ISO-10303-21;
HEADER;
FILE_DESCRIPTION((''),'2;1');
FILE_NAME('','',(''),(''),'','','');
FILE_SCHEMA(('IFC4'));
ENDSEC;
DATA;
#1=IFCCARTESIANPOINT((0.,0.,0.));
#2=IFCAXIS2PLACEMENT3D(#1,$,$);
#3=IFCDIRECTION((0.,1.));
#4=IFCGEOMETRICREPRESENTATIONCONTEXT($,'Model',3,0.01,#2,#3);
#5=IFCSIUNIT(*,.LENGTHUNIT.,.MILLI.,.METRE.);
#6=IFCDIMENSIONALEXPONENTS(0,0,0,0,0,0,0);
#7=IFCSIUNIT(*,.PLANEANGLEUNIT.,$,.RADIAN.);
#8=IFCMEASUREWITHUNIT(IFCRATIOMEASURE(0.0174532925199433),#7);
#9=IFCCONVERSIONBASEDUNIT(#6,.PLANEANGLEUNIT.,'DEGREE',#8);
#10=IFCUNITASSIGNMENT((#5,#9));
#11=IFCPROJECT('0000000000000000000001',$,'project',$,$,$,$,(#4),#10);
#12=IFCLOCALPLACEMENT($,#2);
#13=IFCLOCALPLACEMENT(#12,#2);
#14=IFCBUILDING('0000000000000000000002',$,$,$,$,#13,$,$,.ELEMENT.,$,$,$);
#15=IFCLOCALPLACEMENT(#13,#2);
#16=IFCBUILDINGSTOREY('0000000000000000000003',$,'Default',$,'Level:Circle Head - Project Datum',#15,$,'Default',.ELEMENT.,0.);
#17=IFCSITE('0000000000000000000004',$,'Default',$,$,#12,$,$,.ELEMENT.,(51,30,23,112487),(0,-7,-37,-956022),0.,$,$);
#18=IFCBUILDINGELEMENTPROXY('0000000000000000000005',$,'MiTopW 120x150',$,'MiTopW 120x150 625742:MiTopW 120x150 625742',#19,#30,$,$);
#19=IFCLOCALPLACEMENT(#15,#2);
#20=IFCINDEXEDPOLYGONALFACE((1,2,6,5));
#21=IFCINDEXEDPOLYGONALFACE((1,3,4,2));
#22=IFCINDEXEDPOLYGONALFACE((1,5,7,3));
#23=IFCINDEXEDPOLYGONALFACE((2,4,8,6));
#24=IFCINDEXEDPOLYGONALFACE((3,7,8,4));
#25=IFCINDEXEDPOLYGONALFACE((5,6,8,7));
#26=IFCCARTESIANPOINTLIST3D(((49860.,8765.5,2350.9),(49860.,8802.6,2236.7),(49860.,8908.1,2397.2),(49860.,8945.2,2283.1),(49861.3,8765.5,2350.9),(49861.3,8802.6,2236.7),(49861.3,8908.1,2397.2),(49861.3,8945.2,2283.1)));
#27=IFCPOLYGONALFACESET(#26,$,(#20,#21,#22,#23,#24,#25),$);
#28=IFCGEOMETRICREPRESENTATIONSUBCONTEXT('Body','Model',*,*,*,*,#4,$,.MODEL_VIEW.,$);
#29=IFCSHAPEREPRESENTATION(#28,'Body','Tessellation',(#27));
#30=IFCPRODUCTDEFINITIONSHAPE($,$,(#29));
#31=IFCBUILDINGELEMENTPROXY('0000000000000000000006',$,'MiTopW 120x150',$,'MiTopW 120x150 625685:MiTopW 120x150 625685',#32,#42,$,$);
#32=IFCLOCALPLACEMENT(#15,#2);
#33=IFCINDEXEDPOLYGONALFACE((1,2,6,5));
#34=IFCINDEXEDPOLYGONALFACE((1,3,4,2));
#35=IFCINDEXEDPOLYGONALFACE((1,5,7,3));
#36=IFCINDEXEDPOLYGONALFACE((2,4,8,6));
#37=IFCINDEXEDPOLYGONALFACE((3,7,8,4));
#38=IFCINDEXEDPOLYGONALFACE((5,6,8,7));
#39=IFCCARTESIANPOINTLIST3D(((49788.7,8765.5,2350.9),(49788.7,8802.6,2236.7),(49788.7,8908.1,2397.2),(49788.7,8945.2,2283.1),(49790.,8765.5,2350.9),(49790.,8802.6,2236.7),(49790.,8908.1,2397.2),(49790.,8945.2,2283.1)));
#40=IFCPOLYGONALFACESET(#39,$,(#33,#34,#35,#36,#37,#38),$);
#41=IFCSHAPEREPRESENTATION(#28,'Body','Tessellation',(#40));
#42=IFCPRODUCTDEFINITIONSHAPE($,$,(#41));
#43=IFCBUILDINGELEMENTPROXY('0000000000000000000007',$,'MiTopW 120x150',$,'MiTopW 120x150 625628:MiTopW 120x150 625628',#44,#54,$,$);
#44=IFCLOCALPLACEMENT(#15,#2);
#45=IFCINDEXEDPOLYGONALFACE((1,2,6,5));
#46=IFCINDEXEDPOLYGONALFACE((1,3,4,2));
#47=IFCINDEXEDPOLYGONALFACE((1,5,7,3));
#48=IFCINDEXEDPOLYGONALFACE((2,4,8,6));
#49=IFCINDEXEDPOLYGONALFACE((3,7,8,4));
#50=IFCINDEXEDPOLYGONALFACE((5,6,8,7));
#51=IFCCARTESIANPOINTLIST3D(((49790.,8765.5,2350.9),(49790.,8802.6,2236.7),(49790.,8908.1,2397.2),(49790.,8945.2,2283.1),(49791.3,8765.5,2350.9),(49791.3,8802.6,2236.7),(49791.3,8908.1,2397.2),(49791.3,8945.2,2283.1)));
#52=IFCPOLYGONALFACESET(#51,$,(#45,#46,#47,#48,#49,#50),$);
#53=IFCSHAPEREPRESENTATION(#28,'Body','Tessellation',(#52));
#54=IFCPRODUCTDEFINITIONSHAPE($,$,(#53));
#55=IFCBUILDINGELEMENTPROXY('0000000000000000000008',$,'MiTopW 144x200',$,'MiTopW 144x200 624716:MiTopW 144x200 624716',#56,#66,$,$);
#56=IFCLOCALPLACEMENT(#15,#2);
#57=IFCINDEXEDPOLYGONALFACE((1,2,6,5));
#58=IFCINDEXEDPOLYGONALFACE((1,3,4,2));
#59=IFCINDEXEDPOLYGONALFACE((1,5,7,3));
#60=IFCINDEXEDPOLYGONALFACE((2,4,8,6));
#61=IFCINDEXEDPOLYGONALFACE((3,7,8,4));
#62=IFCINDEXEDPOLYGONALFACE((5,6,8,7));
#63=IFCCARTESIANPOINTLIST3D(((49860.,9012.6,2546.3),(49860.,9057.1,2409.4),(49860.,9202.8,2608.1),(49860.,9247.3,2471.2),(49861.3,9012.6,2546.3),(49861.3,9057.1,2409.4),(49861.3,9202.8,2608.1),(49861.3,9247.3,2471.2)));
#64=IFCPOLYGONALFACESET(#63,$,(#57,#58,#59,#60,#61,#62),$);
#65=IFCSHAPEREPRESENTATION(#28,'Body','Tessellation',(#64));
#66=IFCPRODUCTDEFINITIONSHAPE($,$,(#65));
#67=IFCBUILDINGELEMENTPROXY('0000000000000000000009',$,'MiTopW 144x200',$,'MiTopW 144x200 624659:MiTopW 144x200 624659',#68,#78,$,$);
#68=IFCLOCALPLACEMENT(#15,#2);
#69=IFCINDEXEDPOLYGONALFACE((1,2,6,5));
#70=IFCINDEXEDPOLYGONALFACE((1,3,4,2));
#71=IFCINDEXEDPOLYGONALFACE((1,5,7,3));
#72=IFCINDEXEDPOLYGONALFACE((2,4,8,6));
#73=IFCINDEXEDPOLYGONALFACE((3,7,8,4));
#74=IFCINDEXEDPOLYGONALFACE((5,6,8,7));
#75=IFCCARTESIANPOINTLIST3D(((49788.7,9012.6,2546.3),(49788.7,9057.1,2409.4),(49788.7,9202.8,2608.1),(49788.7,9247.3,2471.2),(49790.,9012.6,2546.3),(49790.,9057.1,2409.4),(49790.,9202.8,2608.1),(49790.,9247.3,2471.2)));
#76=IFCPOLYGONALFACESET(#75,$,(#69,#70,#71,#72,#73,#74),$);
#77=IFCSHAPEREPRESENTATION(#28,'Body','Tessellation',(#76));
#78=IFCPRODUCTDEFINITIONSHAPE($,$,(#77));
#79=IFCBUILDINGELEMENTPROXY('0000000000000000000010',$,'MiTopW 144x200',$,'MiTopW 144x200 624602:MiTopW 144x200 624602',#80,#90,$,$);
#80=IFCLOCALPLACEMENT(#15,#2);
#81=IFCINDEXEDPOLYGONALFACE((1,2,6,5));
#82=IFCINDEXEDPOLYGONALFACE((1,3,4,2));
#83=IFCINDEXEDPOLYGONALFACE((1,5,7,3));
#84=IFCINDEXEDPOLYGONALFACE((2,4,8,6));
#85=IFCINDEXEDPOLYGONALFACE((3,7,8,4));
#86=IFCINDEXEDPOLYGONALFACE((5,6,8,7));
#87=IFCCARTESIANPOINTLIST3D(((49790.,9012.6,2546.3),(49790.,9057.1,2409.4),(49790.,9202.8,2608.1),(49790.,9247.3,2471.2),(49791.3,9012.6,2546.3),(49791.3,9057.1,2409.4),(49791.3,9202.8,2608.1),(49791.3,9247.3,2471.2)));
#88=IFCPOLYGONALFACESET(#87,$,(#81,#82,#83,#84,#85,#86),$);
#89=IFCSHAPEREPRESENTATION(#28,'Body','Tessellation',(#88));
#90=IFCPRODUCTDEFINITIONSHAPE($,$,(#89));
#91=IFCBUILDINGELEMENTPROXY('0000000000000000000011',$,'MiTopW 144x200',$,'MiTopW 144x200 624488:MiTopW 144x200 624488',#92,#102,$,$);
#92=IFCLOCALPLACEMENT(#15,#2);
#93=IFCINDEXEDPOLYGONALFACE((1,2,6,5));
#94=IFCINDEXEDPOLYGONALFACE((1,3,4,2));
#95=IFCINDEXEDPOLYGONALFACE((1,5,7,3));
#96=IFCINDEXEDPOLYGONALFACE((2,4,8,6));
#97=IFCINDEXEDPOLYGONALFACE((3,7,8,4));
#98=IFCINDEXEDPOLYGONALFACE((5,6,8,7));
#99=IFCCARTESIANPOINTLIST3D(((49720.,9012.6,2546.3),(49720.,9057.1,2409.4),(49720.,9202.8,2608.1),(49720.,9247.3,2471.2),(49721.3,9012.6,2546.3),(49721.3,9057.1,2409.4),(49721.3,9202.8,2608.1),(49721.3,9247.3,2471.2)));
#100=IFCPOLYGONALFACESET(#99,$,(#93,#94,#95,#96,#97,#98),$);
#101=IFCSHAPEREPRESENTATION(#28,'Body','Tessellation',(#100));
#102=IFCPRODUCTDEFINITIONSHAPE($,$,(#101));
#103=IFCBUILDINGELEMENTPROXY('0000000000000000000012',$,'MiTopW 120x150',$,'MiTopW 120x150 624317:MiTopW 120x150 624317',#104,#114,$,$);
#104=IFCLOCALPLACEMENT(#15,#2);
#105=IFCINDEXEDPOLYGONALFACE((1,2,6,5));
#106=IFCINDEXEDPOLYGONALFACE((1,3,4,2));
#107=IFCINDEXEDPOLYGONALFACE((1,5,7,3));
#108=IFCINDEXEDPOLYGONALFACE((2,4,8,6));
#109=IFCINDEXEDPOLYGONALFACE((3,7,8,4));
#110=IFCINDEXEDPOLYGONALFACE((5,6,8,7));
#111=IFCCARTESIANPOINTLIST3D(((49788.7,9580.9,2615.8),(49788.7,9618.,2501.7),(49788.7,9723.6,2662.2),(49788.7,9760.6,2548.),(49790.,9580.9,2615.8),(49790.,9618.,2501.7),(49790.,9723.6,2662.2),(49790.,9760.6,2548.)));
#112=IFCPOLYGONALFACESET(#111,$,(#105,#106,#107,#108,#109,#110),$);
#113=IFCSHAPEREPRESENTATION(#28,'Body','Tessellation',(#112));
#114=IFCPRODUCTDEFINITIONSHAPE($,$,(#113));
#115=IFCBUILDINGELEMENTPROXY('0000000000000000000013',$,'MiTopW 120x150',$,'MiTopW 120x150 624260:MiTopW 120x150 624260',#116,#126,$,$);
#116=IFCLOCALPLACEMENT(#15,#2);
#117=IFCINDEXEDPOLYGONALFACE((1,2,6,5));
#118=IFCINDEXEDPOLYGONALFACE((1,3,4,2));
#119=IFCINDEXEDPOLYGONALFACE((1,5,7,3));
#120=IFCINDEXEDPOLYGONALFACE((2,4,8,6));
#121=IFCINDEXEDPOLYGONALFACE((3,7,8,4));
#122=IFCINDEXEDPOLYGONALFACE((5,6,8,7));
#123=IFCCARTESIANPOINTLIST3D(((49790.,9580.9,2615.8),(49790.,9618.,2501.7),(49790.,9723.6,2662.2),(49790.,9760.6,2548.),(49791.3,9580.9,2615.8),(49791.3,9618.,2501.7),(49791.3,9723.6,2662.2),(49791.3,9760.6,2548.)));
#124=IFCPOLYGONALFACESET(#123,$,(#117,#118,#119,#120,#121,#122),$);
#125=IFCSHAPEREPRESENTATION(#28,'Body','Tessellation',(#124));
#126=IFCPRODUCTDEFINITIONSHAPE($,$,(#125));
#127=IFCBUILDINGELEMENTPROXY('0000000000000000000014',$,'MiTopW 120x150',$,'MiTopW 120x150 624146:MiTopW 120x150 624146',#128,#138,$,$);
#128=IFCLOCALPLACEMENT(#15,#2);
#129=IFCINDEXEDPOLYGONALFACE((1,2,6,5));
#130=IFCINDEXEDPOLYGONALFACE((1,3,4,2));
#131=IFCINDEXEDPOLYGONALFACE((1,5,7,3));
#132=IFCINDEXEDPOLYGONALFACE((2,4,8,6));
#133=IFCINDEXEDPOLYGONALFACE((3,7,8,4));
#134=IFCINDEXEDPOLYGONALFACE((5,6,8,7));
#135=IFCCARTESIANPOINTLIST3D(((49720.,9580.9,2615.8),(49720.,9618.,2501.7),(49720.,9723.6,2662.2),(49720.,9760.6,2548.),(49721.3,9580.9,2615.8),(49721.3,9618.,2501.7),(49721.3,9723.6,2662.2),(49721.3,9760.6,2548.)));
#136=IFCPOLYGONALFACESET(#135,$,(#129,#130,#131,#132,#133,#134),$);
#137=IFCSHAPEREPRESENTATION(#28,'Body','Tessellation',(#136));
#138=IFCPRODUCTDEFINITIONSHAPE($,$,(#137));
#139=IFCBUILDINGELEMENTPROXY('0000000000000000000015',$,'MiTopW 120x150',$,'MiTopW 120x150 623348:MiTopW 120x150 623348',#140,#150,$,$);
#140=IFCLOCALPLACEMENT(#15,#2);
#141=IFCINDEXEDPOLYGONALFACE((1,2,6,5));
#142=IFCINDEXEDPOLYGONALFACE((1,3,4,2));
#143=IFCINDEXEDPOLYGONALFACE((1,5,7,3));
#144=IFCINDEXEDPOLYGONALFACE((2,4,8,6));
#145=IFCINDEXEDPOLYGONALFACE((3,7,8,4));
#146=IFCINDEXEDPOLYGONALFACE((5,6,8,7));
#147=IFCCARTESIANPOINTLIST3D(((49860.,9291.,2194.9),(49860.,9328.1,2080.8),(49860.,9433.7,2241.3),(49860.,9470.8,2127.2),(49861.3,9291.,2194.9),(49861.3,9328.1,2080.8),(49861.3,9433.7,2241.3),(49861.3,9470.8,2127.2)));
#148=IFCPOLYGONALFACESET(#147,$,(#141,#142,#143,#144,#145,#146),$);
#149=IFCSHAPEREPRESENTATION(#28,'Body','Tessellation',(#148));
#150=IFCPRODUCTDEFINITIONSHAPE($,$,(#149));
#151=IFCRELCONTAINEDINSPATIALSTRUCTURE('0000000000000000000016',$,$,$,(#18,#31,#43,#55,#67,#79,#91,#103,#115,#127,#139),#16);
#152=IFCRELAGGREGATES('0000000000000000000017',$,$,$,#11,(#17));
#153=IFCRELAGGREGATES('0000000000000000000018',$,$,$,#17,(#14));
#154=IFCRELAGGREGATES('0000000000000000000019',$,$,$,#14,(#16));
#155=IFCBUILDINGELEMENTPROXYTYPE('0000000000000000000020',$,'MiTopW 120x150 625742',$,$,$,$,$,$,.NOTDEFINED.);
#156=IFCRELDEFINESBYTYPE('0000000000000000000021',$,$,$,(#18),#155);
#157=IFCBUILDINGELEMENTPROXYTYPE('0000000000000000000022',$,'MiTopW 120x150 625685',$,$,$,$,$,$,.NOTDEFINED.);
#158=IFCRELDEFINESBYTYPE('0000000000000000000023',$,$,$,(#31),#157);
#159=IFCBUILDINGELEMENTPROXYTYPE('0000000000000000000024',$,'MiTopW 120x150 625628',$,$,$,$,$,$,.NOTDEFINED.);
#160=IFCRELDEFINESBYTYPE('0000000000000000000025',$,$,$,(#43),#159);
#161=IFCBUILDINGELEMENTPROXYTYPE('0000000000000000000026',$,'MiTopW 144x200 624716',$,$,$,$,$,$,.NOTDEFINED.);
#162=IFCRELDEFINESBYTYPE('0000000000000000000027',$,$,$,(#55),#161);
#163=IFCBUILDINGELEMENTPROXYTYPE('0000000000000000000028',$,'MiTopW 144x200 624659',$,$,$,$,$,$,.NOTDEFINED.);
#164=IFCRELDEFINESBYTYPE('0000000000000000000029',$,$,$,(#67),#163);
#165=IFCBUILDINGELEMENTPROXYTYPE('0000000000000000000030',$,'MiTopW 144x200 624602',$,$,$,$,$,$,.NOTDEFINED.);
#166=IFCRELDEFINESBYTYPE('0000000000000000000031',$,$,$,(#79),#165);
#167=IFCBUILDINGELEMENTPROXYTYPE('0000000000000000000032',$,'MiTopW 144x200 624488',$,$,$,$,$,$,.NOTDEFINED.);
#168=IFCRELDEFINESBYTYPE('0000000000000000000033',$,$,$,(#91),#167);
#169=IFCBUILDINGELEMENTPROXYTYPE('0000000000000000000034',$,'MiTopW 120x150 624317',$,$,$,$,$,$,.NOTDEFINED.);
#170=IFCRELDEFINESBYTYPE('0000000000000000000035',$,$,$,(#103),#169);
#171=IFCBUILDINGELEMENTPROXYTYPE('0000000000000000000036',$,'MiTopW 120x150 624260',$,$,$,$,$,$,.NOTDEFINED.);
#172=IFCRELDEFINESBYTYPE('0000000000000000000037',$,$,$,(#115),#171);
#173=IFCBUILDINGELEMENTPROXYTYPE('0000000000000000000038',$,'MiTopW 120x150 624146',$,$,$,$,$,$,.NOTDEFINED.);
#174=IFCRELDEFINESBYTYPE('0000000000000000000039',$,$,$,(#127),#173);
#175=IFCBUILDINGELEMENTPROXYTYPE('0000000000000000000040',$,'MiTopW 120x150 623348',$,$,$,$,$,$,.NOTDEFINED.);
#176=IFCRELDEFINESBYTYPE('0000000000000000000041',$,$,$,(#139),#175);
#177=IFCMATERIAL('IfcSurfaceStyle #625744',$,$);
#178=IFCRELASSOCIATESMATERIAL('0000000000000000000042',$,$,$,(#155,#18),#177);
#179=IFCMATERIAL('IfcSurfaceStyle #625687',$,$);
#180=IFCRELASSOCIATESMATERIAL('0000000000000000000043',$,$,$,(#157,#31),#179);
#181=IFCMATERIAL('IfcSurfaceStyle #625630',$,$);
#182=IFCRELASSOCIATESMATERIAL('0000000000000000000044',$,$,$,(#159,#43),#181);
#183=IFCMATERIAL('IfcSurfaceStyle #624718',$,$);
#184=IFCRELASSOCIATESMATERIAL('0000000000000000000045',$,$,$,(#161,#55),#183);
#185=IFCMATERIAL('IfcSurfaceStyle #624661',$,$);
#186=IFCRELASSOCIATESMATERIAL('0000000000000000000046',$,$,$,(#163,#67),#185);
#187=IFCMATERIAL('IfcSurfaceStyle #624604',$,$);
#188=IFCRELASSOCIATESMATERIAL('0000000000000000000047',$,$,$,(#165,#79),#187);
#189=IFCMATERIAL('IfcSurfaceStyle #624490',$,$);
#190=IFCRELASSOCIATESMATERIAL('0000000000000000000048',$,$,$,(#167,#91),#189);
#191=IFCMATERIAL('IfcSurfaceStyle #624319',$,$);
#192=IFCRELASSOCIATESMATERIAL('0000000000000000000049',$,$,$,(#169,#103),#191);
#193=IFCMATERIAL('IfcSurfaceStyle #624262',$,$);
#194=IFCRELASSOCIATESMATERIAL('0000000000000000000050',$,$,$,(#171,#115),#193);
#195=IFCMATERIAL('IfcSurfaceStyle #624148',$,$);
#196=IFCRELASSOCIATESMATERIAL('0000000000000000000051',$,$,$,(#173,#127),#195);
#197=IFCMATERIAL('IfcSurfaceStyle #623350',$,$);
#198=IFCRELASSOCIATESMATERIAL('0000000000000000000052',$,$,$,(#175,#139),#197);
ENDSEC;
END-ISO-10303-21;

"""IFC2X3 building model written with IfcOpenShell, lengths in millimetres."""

from ifc_helpers import new_model, entity, si_unit, converted_unit, direction, frame, origin, place, context, subcontext, project, spatial, polyline, outline, extrude, source, transform, mapped, material, type_object, type_shapes, element, save


model = new_model("IFC2X3")

# Units and contexts
model_context = context("Model", 3, precision=0.01, world=origin(), true_north=direction((0.0, 1.0)))
body_context = subcontext(model_context, "Body", "Model", "MODEL_VIEW")
ifc_project = project(units=[si_unit("LENGTHUNIT", "METRE", prefix="MILLI"), converted_unit("PLANEANGLEUNIT", "DEGREE", entity("IfcRatioMeasure", 0.0174532925199433), si_unit("PLANEANGLEUNIT", "RADIAN"), dimensions=[0, 0, 0, 0, 0, 0, 0])], contexts=[model_context])

# Site, building, storey
site_placement = place(None, origin())
site = spatial("IfcSite", under=ifc_project, at=site_placement, Name="Default", CompositionType="ELEMENT", RefLatitude=(51, 30, 23, 112487), RefLongitude=(0, -7, -37, -956022), RefElevation=0.0)
building_placement = place(site_placement, origin())
building = spatial("IfcBuilding", under=site, at=building_placement, CompositionType="ELEMENT")
storey_placement = place(building_placement, origin())
storey = spatial("IfcBuildingStorey", under=building, at=storey_placement, Name="Default", ObjectType="Level:Circle Head - Project Datum", LongName="Default", CompositionType="ELEMENT", Elevation=0.0)

# Building element proxies
ifc_material_1 = material(Name="IfcSurfaceStyle #625744")
building_element_proxy_type_1 = type_object("IfcBuildingElementProxyType", Name="MiTopW 120x150 625742", PredefinedType="NOTDEFINED", material=ifc_material_1)
shared_shape_1 = source(origin(), body_context, "Body", "SweptSolid", [
    extrude(outline(polyline([(-75.0, -60.0), (75.0, -60.0), (75.0, 60.0), (-75.0, 60.0), (-75.0, -60.0)])), frame((75.0, 60.0, 0.0), z_axis=(0.0, 0.0, 1.0), x_axis=(-1.0, 0.0, 0.0)), (0.0, 0.0, 1.0), 1.3),
])
type_shapes(building_element_proxy_type_1, [shared_shape_1])
proxy_1_placement = place(building_placement, frame((49861.3, 8765.5, 2350.9), z_axis=(-1.0, 0.0, 0.0), x_axis=(0.0, 0.951057, 0.309017)))
element("IfcBuildingElementProxy", 1, at=proxy_1_placement, inside=storey, type_object=building_element_proxy_type_1, material=ifc_material_1, Name="MiTopW 120x150", ObjectType="MiTopW 120x150 625742:MiTopW 120x150 625742", context=body_context, shape_type="MappedRepresentation", body=[
    mapped(shared_shape_1, transform((0.0, 0.0, 0.0), scale=1.0)),
])
ifc_material_2 = material(Name="IfcSurfaceStyle #625687")
building_element_proxy_type_2 = type_object("IfcBuildingElementProxyType", Name="MiTopW 120x150 625685", PredefinedType="NOTDEFINED", material=ifc_material_2)
shared_shape_2 = source(origin(), body_context, "Body", "SweptSolid", [
    extrude(outline(polyline([(-75.0, -60.0), (75.0, -60.0), (75.0, 60.0), (-75.0, 60.0), (-75.0, -60.0)])), frame((75.0, 60.0, 0.0), z_axis=(0.0, 0.0, 1.0), x_axis=(-1.0, 0.0, 0.0)), (0.0, 0.0, 1.0), 1.3),
])
type_shapes(building_element_proxy_type_2, [shared_shape_2])
proxy_2_placement = place(building_placement, frame((49790.0, 8765.5, 2350.9), z_axis=(-1.0, 0.0, 0.0), x_axis=(0.0, 0.951057, 0.309017)))
element("IfcBuildingElementProxy", 2, at=proxy_2_placement, inside=storey, type_object=building_element_proxy_type_2, material=ifc_material_2, Name="MiTopW 120x150", ObjectType="MiTopW 120x150 625685:MiTopW 120x150 625685", context=body_context, shape_type="MappedRepresentation", body=[
    mapped(shared_shape_2, transform((0.0, 0.0, 0.0), scale=1.0)),
])
ifc_material_3 = material(Name="IfcSurfaceStyle #625630")
building_element_proxy_type_3 = type_object("IfcBuildingElementProxyType", Name="MiTopW 120x150 625628", PredefinedType="NOTDEFINED", material=ifc_material_3)
shared_shape_3 = source(origin(), body_context, "Body", "SweptSolid", [
    extrude(outline(polyline([(-75.0, -60.0), (75.0, -60.0), (75.0, 60.0), (-75.0, 60.0), (-75.0, -60.0)])), frame((75.0, 60.0, 0.0), z_axis=(0.0, 0.0, 1.0), x_axis=(-1.0, 0.0, 0.0)), (0.0, 0.0, 1.0), 1.3),
])
type_shapes(building_element_proxy_type_3, [shared_shape_3])
proxy_3_placement = place(building_placement, frame((49791.3, 8765.5, 2350.9), z_axis=(-1.0, 0.0, 0.0), x_axis=(0.0, 0.951057, 0.309017)))
element("IfcBuildingElementProxy", 3, at=proxy_3_placement, inside=storey, type_object=building_element_proxy_type_3, material=ifc_material_3, Name="MiTopW 120x150", ObjectType="MiTopW 120x150 625628:MiTopW 120x150 625628", context=body_context, shape_type="MappedRepresentation", body=[
    mapped(shared_shape_3, transform((0.0, 0.0, 0.0), scale=1.0)),
])
ifc_material_4 = material(Name="IfcSurfaceStyle #624718")
building_element_proxy_type_4 = type_object("IfcBuildingElementProxyType", Name="MiTopW 144x200 624716", PredefinedType="NOTDEFINED", material=ifc_material_4)
shared_shape_4 = source(origin(), body_context, "Body", "SweptSolid", [
    extrude(outline(polyline([(-100.0, -72.0), (100.0, -72.0), (100.0, 72.0), (-100.0, 72.0), (-100.0, -72.0)])), frame((100.0, 72.0, 0.0), z_axis=(0.0, 0.0, 1.0), x_axis=(-1.0, 0.0, 0.0)), (0.0, 0.0, 1.0), 1.3),
])
type_shapes(building_element_proxy_type_4, [shared_shape_4])
proxy_4_placement = place(building_placement, frame((49861.3, 9012.6, 2546.3), z_axis=(-1.0, 0.0, 0.0), x_axis=(0.0, 0.951057, 0.309017)))
element("IfcBuildingElementProxy", 4, at=proxy_4_placement, inside=storey, type_object=building_element_proxy_type_4, material=ifc_material_4, Name="MiTopW 144x200", ObjectType="MiTopW 144x200 624716:MiTopW 144x200 624716", context=body_context, shape_type="MappedRepresentation", body=[
    mapped(shared_shape_4, transform((0.0, 0.0, 0.0), scale=1.0)),
])
ifc_material_5 = material(Name="IfcSurfaceStyle #624661")
building_element_proxy_type_5 = type_object("IfcBuildingElementProxyType", Name="MiTopW 144x200 624659", PredefinedType="NOTDEFINED", material=ifc_material_5)
shared_shape_5 = source(origin(), body_context, "Body", "SweptSolid", [
    extrude(outline(polyline([(-100.0, -72.0), (100.0, -72.0), (100.0, 72.0), (-100.0, 72.0), (-100.0, -72.0)])), frame((100.0, 72.0, 0.0), z_axis=(0.0, 0.0, 1.0), x_axis=(-1.0, 0.0, 0.0)), (0.0, 0.0, 1.0), 1.3),
])
type_shapes(building_element_proxy_type_5, [shared_shape_5])
proxy_5_placement = place(building_placement, frame((49790.0, 9012.6, 2546.3), z_axis=(-1.0, 0.0, 0.0), x_axis=(0.0, 0.951057, 0.309017)))
element("IfcBuildingElementProxy", 5, at=proxy_5_placement, inside=storey, type_object=building_element_proxy_type_5, material=ifc_material_5, Name="MiTopW 144x200", ObjectType="MiTopW 144x200 624659:MiTopW 144x200 624659", context=body_context, shape_type="MappedRepresentation", body=[
    mapped(shared_shape_5, transform((0.0, 0.0, 0.0), scale=1.0)),
])
ifc_material_6 = material(Name="IfcSurfaceStyle #624604")
building_element_proxy_type_6 = type_object("IfcBuildingElementProxyType", Name="MiTopW 144x200 624602", PredefinedType="NOTDEFINED", material=ifc_material_6)
shared_shape_6 = source(origin(), body_context, "Body", "SweptSolid", [
    extrude(outline(polyline([(-100.0, -72.0), (100.0, -72.0), (100.0, 72.0), (-100.0, 72.0), (-100.0, -72.0)])), frame((100.0, 72.0, 0.0), z_axis=(0.0, 0.0, 1.0), x_axis=(-1.0, 0.0, 0.0)), (0.0, 0.0, 1.0), 1.3),
])
type_shapes(building_element_proxy_type_6, [shared_shape_6])
proxy_6_placement = place(building_placement, frame((49791.3, 9012.6, 2546.3), z_axis=(-1.0, 0.0, 0.0), x_axis=(0.0, 0.951057, 0.309017)))
element("IfcBuildingElementProxy", 6, at=proxy_6_placement, inside=storey, type_object=building_element_proxy_type_6, material=ifc_material_6, Name="MiTopW 144x200", ObjectType="MiTopW 144x200 624602:MiTopW 144x200 624602", context=body_context, shape_type="MappedRepresentation", body=[
    mapped(shared_shape_6, transform((0.0, 0.0, 0.0), scale=1.0)),
])
ifc_material_7 = material(Name="IfcSurfaceStyle #624490")
building_element_proxy_type_7 = type_object("IfcBuildingElementProxyType", Name="MiTopW 144x200 624488", PredefinedType="NOTDEFINED", material=ifc_material_7)
shared_shape_7 = source(origin(), body_context, "Body", "SweptSolid", [
    extrude(outline(polyline([(-100.0, -72.0), (100.0, -72.0), (100.0, 72.0), (-100.0, 72.0), (-100.0, -72.0)])), frame((100.0, 72.0, 0.0), z_axis=(0.0, 0.0, 1.0), x_axis=(-1.0, 0.0, 0.0)), (0.0, 0.0, 1.0), 1.3),
])
type_shapes(building_element_proxy_type_7, [shared_shape_7])
proxy_7_placement = place(building_placement, frame((49721.3, 9012.6, 2546.3), z_axis=(-1.0, 0.0, 0.0), x_axis=(0.0, 0.951057, 0.309017)))
element("IfcBuildingElementProxy", 7, at=proxy_7_placement, inside=storey, type_object=building_element_proxy_type_7, material=ifc_material_7, Name="MiTopW 144x200", ObjectType="MiTopW 144x200 624488:MiTopW 144x200 624488", context=body_context, shape_type="MappedRepresentation", body=[
    mapped(shared_shape_7, transform((0.0, 0.0, 0.0), scale=1.0)),
])
ifc_material_8 = material(Name="IfcSurfaceStyle #624319")
building_element_proxy_type_8 = type_object("IfcBuildingElementProxyType", Name="MiTopW 120x150 624317", PredefinedType="NOTDEFINED", material=ifc_material_8)
shared_shape_8 = source(origin(), body_context, "Body", "SweptSolid", [
    extrude(outline(polyline([(-75.0, -60.0), (75.0, -60.0), (75.0, 60.0), (-75.0, 60.0), (-75.0, -60.0)])), frame((75.0, 60.0, 0.0), z_axis=(0.0, 0.0, 1.0), x_axis=(-1.0, 0.0, 0.0)), (0.0, 0.0, 1.0), 1.3),
])
type_shapes(building_element_proxy_type_8, [shared_shape_8])
proxy_8_placement = place(building_placement, frame((49790.0, 9580.9, 2615.8), z_axis=(-1.0, 0.0, 0.0), x_axis=(0.0, 0.951057, 0.309017)))
element("IfcBuildingElementProxy", 8, at=proxy_8_placement, inside=storey, type_object=building_element_proxy_type_8, material=ifc_material_8, Name="MiTopW 120x150", ObjectType="MiTopW 120x150 624317:MiTopW 120x150 624317", context=body_context, shape_type="MappedRepresentation", body=[
    mapped(shared_shape_8, transform((0.0, 0.0, 0.0), scale=1.0)),
])
ifc_material_9 = material(Name="IfcSurfaceStyle #624262")
building_element_proxy_type_9 = type_object("IfcBuildingElementProxyType", Name="MiTopW 120x150 624260", PredefinedType="NOTDEFINED", material=ifc_material_9)
shared_shape_9 = source(origin(), body_context, "Body", "SweptSolid", [
    extrude(outline(polyline([(-75.0, -60.0), (75.0, -60.0), (75.0, 60.0), (-75.0, 60.0), (-75.0, -60.0)])), frame((75.0, 60.0, 0.0), z_axis=(0.0, 0.0, 1.0), x_axis=(-1.0, 0.0, 0.0)), (0.0, 0.0, 1.0), 1.3),
])
type_shapes(building_element_proxy_type_9, [shared_shape_9])
proxy_9_placement = place(building_placement, frame((49791.3, 9580.9, 2615.8), z_axis=(-1.0, 0.0, 0.0), x_axis=(0.0, 0.951057, 0.309017)))
element("IfcBuildingElementProxy", 9, at=proxy_9_placement, inside=storey, type_object=building_element_proxy_type_9, material=ifc_material_9, Name="MiTopW 120x150", ObjectType="MiTopW 120x150 624260:MiTopW 120x150 624260", context=body_context, shape_type="MappedRepresentation", body=[
    mapped(shared_shape_9, transform((0.0, 0.0, 0.0), scale=1.0)),
])
ifc_material_10 = material(Name="IfcSurfaceStyle #624148")
building_element_proxy_type_10 = type_object("IfcBuildingElementProxyType", Name="MiTopW 120x150 624146", PredefinedType="NOTDEFINED", material=ifc_material_10)
shared_shape_10 = source(origin(), body_context, "Body", "SweptSolid", [
    extrude(outline(polyline([(-75.0, -60.0), (75.0, -60.0), (75.0, 60.0), (-75.0, 60.0), (-75.0, -60.0)])), frame((75.0, 60.0, 0.0), z_axis=(0.0, 0.0, 1.0), x_axis=(-1.0, 0.0, 0.0)), (0.0, 0.0, 1.0), 1.3),
])
type_shapes(building_element_proxy_type_10, [shared_shape_10])
proxy_10_placement = place(building_placement, frame((49721.3, 9580.9, 2615.8), z_axis=(-1.0, 0.0, 0.0), x_axis=(0.0, 0.951057, 0.309017)))
element("IfcBuildingElementProxy", 10, at=proxy_10_placement, inside=storey, type_object=building_element_proxy_type_10, material=ifc_material_10, Name="MiTopW 120x150", ObjectType="MiTopW 120x150 624146:MiTopW 120x150 624146", context=body_context, shape_type="MappedRepresentation", body=[
    mapped(shared_shape_10, transform((0.0, 0.0, 0.0), scale=1.0)),
])
ifc_material_11 = material(Name="IfcSurfaceStyle #623350")
building_element_proxy_type_11 = type_object("IfcBuildingElementProxyType", Name="MiTopW 120x150 623348", PredefinedType="NOTDEFINED", material=ifc_material_11)
shared_shape_11 = source(origin(), body_context, "Body", "SweptSolid", [
    extrude(outline(polyline([(-75.0, -60.0), (75.0, -60.0), (75.0, 60.0), (-75.0, 60.0), (-75.0, -60.0)])), frame((75.0, 60.0, 0.0), z_axis=(0.0, 0.0, 1.0), x_axis=(-1.0, 0.0, 0.0)), (0.0, 0.0, 1.0), 1.3),
])
type_shapes(building_element_proxy_type_11, [shared_shape_11])
proxy_11_placement = place(building_placement, frame((49861.3, 9291.0, 2194.9), z_axis=(-1.0, 0.0, 0.0), x_axis=(0.0, 0.951057, 0.309017)))
element("IfcBuildingElementProxy", 11, at=proxy_11_placement, inside=storey, type_object=building_element_proxy_type_11, material=ifc_material_11, Name="MiTopW 120x150", ObjectType="MiTopW 120x150 623348:MiTopW 120x150 623348", context=body_context, shape_type="MappedRepresentation", body=[
    mapped(shared_shape_11, transform((0.0, 0.0, 0.0), scale=1.0)),
])

save(model, "model.ifc")
